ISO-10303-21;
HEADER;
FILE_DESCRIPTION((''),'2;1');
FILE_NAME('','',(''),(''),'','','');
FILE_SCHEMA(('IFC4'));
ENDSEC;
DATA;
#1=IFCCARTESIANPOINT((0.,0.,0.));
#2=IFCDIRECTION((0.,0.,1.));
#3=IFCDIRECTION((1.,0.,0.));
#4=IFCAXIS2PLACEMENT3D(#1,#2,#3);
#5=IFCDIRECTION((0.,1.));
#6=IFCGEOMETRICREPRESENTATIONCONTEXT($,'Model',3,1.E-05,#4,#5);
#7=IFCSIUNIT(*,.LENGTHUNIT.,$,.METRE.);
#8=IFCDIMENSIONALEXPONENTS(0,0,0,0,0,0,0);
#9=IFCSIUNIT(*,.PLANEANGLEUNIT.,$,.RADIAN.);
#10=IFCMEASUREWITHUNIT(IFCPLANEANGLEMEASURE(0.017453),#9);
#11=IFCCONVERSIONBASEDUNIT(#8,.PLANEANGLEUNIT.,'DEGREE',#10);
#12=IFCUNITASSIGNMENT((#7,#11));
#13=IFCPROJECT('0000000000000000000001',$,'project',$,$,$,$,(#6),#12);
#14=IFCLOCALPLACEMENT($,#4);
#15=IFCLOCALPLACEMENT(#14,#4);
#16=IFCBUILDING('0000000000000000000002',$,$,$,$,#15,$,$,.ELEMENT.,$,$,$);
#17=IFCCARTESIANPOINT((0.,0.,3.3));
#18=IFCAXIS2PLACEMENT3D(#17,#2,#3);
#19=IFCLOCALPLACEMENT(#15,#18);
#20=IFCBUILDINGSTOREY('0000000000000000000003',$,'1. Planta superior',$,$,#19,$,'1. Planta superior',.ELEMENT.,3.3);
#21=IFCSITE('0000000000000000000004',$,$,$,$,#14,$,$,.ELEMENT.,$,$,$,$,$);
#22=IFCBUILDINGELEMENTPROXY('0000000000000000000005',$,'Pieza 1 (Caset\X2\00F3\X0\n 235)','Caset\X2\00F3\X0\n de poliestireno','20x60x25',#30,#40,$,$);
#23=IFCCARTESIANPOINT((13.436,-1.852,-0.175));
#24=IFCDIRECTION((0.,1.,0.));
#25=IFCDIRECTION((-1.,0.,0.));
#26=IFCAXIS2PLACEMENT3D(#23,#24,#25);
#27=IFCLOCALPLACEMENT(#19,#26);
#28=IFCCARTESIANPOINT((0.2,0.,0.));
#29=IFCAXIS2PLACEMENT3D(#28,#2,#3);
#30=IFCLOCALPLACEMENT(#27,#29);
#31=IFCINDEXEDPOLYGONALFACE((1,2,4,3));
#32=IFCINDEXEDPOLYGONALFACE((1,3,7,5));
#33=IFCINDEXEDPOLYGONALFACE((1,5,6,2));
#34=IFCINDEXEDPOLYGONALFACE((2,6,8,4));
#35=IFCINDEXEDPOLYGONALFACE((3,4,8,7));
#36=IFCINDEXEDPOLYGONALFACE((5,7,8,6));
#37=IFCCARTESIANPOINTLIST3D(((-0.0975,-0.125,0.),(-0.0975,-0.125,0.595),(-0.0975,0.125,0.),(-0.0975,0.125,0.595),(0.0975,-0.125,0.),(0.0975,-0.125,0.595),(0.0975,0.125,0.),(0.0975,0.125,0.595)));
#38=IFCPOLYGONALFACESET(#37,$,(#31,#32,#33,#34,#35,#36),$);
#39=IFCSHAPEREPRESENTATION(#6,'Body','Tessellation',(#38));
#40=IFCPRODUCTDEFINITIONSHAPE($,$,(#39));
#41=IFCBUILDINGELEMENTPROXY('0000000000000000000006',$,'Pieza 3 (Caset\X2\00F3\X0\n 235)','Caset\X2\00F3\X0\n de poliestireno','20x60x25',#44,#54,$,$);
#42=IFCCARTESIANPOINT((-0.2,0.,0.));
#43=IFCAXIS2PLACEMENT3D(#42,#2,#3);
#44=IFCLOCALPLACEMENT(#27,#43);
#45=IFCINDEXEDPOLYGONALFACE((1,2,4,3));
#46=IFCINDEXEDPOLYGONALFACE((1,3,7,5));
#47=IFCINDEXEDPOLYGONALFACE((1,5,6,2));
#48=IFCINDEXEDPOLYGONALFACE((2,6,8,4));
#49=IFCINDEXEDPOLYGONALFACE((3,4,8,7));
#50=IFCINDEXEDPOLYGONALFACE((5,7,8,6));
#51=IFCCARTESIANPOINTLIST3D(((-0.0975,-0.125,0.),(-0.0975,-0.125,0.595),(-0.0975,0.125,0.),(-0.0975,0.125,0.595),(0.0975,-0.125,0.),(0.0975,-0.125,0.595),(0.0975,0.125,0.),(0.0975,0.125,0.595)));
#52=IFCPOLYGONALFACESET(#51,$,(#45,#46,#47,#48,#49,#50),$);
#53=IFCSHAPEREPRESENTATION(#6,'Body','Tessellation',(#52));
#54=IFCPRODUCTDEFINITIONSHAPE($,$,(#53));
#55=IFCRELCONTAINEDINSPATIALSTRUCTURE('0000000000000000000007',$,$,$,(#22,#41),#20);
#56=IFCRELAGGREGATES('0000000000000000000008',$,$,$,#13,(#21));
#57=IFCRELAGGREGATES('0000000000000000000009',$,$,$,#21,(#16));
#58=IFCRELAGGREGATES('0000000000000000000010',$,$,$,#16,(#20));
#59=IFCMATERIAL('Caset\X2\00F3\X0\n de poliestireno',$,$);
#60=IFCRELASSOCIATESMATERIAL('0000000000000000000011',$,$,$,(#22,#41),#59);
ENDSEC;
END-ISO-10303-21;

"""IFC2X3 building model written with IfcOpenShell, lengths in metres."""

from ifc_helpers import new_model, entity, si_unit, converted_unit, direction, frame, origin_with_axes, origin_2d_with_axis, place, context, project, spatial, rectangle, extrude, source, transform, mapped, material, element, save


model = new_model("IFC2X3")

# Units and contexts
model_context = context("Model", 3, precision=1e-05, world=origin_with_axes(), true_north=direction((0.0, 1.0)))
ifc_project = project(units=[si_unit("LENGTHUNIT", "METRE"), converted_unit("PLANEANGLEUNIT", "DEGREE", entity("IfcPlaneAngleMeasure", 0.017453), si_unit("PLANEANGLEUNIT", "RADIAN"), dimensions=[0, 0, 0, 0, 0, 0, 0])], contexts=[model_context])

# Site, building, storey
site_placement = place(None, origin_with_axes())
site = spatial("IfcSite", under=ifc_project, at=site_placement, CompositionType="ELEMENT")
building_placement = place(site_placement, origin_with_axes())
building = spatial("IfcBuilding", under=site, at=building_placement, CompositionType="ELEMENT")
storey_placement = place(building_placement, frame((0.0, 0.0, 3.3), z_axis=(0.0, 0.0, 1.0), x_axis=(1.0, 0.0, 0.0)))
storey = spatial("IfcBuildingStorey", under=building, at=storey_placement, Name="1. Planta superior", LongName="1. Planta superior", CompositionType="ELEMENT", Elevation=3.3)

# Building element proxies
ifc_material = material(Name="Casetón de poliestireno")
shared_shape = source(origin_with_axes(), model_context, "Body", "SweptSolid", [
    extrude(rectangle(XDim=0.195, YDim=0.25, at=origin_2d_with_axis()), origin_with_axes(), (0.0, 0.0, 1.0), 0.595),
])
placement_1 = place(storey_placement, frame((13.436, -1.852, -0.175), z_axis=(0.0, 1.0, 0.0), x_axis=(-1.0, 0.0, 0.0)))
for number, where, z_axis, x_axis, name in (
    (1, (0.2, 0.0, 0.0), (0.0, 0.0, 1.0), (1.0, 0.0, 0.0), "Pieza 1 (Casetón 235)"),
    (2, (-0.2, 0.0, 0.0), (0.0, 0.0, 1.0), (1.0, 0.0, 0.0), "Pieza 3 (Casetón 235)"),
):
    element("IfcBuildingElementProxy", number, at=place(placement_1, frame(where, z_axis=z_axis, x_axis=x_axis)), inside=storey, material=ifc_material, Name=name, Description="Casetón de poliestireno", ObjectType="20x60x25", context=model_context, shape_type="MappedRepresentation", body=[
        mapped(shared_shape, transform((0.0, 0.0, 0.0), x_axis=(1.0, 0.0, 0.0), y_axis=(0.0, 1.0, 0.0), z_axis=(0.0, 0.0, 1.0))),
    ])

save(model, "model.ifc")
